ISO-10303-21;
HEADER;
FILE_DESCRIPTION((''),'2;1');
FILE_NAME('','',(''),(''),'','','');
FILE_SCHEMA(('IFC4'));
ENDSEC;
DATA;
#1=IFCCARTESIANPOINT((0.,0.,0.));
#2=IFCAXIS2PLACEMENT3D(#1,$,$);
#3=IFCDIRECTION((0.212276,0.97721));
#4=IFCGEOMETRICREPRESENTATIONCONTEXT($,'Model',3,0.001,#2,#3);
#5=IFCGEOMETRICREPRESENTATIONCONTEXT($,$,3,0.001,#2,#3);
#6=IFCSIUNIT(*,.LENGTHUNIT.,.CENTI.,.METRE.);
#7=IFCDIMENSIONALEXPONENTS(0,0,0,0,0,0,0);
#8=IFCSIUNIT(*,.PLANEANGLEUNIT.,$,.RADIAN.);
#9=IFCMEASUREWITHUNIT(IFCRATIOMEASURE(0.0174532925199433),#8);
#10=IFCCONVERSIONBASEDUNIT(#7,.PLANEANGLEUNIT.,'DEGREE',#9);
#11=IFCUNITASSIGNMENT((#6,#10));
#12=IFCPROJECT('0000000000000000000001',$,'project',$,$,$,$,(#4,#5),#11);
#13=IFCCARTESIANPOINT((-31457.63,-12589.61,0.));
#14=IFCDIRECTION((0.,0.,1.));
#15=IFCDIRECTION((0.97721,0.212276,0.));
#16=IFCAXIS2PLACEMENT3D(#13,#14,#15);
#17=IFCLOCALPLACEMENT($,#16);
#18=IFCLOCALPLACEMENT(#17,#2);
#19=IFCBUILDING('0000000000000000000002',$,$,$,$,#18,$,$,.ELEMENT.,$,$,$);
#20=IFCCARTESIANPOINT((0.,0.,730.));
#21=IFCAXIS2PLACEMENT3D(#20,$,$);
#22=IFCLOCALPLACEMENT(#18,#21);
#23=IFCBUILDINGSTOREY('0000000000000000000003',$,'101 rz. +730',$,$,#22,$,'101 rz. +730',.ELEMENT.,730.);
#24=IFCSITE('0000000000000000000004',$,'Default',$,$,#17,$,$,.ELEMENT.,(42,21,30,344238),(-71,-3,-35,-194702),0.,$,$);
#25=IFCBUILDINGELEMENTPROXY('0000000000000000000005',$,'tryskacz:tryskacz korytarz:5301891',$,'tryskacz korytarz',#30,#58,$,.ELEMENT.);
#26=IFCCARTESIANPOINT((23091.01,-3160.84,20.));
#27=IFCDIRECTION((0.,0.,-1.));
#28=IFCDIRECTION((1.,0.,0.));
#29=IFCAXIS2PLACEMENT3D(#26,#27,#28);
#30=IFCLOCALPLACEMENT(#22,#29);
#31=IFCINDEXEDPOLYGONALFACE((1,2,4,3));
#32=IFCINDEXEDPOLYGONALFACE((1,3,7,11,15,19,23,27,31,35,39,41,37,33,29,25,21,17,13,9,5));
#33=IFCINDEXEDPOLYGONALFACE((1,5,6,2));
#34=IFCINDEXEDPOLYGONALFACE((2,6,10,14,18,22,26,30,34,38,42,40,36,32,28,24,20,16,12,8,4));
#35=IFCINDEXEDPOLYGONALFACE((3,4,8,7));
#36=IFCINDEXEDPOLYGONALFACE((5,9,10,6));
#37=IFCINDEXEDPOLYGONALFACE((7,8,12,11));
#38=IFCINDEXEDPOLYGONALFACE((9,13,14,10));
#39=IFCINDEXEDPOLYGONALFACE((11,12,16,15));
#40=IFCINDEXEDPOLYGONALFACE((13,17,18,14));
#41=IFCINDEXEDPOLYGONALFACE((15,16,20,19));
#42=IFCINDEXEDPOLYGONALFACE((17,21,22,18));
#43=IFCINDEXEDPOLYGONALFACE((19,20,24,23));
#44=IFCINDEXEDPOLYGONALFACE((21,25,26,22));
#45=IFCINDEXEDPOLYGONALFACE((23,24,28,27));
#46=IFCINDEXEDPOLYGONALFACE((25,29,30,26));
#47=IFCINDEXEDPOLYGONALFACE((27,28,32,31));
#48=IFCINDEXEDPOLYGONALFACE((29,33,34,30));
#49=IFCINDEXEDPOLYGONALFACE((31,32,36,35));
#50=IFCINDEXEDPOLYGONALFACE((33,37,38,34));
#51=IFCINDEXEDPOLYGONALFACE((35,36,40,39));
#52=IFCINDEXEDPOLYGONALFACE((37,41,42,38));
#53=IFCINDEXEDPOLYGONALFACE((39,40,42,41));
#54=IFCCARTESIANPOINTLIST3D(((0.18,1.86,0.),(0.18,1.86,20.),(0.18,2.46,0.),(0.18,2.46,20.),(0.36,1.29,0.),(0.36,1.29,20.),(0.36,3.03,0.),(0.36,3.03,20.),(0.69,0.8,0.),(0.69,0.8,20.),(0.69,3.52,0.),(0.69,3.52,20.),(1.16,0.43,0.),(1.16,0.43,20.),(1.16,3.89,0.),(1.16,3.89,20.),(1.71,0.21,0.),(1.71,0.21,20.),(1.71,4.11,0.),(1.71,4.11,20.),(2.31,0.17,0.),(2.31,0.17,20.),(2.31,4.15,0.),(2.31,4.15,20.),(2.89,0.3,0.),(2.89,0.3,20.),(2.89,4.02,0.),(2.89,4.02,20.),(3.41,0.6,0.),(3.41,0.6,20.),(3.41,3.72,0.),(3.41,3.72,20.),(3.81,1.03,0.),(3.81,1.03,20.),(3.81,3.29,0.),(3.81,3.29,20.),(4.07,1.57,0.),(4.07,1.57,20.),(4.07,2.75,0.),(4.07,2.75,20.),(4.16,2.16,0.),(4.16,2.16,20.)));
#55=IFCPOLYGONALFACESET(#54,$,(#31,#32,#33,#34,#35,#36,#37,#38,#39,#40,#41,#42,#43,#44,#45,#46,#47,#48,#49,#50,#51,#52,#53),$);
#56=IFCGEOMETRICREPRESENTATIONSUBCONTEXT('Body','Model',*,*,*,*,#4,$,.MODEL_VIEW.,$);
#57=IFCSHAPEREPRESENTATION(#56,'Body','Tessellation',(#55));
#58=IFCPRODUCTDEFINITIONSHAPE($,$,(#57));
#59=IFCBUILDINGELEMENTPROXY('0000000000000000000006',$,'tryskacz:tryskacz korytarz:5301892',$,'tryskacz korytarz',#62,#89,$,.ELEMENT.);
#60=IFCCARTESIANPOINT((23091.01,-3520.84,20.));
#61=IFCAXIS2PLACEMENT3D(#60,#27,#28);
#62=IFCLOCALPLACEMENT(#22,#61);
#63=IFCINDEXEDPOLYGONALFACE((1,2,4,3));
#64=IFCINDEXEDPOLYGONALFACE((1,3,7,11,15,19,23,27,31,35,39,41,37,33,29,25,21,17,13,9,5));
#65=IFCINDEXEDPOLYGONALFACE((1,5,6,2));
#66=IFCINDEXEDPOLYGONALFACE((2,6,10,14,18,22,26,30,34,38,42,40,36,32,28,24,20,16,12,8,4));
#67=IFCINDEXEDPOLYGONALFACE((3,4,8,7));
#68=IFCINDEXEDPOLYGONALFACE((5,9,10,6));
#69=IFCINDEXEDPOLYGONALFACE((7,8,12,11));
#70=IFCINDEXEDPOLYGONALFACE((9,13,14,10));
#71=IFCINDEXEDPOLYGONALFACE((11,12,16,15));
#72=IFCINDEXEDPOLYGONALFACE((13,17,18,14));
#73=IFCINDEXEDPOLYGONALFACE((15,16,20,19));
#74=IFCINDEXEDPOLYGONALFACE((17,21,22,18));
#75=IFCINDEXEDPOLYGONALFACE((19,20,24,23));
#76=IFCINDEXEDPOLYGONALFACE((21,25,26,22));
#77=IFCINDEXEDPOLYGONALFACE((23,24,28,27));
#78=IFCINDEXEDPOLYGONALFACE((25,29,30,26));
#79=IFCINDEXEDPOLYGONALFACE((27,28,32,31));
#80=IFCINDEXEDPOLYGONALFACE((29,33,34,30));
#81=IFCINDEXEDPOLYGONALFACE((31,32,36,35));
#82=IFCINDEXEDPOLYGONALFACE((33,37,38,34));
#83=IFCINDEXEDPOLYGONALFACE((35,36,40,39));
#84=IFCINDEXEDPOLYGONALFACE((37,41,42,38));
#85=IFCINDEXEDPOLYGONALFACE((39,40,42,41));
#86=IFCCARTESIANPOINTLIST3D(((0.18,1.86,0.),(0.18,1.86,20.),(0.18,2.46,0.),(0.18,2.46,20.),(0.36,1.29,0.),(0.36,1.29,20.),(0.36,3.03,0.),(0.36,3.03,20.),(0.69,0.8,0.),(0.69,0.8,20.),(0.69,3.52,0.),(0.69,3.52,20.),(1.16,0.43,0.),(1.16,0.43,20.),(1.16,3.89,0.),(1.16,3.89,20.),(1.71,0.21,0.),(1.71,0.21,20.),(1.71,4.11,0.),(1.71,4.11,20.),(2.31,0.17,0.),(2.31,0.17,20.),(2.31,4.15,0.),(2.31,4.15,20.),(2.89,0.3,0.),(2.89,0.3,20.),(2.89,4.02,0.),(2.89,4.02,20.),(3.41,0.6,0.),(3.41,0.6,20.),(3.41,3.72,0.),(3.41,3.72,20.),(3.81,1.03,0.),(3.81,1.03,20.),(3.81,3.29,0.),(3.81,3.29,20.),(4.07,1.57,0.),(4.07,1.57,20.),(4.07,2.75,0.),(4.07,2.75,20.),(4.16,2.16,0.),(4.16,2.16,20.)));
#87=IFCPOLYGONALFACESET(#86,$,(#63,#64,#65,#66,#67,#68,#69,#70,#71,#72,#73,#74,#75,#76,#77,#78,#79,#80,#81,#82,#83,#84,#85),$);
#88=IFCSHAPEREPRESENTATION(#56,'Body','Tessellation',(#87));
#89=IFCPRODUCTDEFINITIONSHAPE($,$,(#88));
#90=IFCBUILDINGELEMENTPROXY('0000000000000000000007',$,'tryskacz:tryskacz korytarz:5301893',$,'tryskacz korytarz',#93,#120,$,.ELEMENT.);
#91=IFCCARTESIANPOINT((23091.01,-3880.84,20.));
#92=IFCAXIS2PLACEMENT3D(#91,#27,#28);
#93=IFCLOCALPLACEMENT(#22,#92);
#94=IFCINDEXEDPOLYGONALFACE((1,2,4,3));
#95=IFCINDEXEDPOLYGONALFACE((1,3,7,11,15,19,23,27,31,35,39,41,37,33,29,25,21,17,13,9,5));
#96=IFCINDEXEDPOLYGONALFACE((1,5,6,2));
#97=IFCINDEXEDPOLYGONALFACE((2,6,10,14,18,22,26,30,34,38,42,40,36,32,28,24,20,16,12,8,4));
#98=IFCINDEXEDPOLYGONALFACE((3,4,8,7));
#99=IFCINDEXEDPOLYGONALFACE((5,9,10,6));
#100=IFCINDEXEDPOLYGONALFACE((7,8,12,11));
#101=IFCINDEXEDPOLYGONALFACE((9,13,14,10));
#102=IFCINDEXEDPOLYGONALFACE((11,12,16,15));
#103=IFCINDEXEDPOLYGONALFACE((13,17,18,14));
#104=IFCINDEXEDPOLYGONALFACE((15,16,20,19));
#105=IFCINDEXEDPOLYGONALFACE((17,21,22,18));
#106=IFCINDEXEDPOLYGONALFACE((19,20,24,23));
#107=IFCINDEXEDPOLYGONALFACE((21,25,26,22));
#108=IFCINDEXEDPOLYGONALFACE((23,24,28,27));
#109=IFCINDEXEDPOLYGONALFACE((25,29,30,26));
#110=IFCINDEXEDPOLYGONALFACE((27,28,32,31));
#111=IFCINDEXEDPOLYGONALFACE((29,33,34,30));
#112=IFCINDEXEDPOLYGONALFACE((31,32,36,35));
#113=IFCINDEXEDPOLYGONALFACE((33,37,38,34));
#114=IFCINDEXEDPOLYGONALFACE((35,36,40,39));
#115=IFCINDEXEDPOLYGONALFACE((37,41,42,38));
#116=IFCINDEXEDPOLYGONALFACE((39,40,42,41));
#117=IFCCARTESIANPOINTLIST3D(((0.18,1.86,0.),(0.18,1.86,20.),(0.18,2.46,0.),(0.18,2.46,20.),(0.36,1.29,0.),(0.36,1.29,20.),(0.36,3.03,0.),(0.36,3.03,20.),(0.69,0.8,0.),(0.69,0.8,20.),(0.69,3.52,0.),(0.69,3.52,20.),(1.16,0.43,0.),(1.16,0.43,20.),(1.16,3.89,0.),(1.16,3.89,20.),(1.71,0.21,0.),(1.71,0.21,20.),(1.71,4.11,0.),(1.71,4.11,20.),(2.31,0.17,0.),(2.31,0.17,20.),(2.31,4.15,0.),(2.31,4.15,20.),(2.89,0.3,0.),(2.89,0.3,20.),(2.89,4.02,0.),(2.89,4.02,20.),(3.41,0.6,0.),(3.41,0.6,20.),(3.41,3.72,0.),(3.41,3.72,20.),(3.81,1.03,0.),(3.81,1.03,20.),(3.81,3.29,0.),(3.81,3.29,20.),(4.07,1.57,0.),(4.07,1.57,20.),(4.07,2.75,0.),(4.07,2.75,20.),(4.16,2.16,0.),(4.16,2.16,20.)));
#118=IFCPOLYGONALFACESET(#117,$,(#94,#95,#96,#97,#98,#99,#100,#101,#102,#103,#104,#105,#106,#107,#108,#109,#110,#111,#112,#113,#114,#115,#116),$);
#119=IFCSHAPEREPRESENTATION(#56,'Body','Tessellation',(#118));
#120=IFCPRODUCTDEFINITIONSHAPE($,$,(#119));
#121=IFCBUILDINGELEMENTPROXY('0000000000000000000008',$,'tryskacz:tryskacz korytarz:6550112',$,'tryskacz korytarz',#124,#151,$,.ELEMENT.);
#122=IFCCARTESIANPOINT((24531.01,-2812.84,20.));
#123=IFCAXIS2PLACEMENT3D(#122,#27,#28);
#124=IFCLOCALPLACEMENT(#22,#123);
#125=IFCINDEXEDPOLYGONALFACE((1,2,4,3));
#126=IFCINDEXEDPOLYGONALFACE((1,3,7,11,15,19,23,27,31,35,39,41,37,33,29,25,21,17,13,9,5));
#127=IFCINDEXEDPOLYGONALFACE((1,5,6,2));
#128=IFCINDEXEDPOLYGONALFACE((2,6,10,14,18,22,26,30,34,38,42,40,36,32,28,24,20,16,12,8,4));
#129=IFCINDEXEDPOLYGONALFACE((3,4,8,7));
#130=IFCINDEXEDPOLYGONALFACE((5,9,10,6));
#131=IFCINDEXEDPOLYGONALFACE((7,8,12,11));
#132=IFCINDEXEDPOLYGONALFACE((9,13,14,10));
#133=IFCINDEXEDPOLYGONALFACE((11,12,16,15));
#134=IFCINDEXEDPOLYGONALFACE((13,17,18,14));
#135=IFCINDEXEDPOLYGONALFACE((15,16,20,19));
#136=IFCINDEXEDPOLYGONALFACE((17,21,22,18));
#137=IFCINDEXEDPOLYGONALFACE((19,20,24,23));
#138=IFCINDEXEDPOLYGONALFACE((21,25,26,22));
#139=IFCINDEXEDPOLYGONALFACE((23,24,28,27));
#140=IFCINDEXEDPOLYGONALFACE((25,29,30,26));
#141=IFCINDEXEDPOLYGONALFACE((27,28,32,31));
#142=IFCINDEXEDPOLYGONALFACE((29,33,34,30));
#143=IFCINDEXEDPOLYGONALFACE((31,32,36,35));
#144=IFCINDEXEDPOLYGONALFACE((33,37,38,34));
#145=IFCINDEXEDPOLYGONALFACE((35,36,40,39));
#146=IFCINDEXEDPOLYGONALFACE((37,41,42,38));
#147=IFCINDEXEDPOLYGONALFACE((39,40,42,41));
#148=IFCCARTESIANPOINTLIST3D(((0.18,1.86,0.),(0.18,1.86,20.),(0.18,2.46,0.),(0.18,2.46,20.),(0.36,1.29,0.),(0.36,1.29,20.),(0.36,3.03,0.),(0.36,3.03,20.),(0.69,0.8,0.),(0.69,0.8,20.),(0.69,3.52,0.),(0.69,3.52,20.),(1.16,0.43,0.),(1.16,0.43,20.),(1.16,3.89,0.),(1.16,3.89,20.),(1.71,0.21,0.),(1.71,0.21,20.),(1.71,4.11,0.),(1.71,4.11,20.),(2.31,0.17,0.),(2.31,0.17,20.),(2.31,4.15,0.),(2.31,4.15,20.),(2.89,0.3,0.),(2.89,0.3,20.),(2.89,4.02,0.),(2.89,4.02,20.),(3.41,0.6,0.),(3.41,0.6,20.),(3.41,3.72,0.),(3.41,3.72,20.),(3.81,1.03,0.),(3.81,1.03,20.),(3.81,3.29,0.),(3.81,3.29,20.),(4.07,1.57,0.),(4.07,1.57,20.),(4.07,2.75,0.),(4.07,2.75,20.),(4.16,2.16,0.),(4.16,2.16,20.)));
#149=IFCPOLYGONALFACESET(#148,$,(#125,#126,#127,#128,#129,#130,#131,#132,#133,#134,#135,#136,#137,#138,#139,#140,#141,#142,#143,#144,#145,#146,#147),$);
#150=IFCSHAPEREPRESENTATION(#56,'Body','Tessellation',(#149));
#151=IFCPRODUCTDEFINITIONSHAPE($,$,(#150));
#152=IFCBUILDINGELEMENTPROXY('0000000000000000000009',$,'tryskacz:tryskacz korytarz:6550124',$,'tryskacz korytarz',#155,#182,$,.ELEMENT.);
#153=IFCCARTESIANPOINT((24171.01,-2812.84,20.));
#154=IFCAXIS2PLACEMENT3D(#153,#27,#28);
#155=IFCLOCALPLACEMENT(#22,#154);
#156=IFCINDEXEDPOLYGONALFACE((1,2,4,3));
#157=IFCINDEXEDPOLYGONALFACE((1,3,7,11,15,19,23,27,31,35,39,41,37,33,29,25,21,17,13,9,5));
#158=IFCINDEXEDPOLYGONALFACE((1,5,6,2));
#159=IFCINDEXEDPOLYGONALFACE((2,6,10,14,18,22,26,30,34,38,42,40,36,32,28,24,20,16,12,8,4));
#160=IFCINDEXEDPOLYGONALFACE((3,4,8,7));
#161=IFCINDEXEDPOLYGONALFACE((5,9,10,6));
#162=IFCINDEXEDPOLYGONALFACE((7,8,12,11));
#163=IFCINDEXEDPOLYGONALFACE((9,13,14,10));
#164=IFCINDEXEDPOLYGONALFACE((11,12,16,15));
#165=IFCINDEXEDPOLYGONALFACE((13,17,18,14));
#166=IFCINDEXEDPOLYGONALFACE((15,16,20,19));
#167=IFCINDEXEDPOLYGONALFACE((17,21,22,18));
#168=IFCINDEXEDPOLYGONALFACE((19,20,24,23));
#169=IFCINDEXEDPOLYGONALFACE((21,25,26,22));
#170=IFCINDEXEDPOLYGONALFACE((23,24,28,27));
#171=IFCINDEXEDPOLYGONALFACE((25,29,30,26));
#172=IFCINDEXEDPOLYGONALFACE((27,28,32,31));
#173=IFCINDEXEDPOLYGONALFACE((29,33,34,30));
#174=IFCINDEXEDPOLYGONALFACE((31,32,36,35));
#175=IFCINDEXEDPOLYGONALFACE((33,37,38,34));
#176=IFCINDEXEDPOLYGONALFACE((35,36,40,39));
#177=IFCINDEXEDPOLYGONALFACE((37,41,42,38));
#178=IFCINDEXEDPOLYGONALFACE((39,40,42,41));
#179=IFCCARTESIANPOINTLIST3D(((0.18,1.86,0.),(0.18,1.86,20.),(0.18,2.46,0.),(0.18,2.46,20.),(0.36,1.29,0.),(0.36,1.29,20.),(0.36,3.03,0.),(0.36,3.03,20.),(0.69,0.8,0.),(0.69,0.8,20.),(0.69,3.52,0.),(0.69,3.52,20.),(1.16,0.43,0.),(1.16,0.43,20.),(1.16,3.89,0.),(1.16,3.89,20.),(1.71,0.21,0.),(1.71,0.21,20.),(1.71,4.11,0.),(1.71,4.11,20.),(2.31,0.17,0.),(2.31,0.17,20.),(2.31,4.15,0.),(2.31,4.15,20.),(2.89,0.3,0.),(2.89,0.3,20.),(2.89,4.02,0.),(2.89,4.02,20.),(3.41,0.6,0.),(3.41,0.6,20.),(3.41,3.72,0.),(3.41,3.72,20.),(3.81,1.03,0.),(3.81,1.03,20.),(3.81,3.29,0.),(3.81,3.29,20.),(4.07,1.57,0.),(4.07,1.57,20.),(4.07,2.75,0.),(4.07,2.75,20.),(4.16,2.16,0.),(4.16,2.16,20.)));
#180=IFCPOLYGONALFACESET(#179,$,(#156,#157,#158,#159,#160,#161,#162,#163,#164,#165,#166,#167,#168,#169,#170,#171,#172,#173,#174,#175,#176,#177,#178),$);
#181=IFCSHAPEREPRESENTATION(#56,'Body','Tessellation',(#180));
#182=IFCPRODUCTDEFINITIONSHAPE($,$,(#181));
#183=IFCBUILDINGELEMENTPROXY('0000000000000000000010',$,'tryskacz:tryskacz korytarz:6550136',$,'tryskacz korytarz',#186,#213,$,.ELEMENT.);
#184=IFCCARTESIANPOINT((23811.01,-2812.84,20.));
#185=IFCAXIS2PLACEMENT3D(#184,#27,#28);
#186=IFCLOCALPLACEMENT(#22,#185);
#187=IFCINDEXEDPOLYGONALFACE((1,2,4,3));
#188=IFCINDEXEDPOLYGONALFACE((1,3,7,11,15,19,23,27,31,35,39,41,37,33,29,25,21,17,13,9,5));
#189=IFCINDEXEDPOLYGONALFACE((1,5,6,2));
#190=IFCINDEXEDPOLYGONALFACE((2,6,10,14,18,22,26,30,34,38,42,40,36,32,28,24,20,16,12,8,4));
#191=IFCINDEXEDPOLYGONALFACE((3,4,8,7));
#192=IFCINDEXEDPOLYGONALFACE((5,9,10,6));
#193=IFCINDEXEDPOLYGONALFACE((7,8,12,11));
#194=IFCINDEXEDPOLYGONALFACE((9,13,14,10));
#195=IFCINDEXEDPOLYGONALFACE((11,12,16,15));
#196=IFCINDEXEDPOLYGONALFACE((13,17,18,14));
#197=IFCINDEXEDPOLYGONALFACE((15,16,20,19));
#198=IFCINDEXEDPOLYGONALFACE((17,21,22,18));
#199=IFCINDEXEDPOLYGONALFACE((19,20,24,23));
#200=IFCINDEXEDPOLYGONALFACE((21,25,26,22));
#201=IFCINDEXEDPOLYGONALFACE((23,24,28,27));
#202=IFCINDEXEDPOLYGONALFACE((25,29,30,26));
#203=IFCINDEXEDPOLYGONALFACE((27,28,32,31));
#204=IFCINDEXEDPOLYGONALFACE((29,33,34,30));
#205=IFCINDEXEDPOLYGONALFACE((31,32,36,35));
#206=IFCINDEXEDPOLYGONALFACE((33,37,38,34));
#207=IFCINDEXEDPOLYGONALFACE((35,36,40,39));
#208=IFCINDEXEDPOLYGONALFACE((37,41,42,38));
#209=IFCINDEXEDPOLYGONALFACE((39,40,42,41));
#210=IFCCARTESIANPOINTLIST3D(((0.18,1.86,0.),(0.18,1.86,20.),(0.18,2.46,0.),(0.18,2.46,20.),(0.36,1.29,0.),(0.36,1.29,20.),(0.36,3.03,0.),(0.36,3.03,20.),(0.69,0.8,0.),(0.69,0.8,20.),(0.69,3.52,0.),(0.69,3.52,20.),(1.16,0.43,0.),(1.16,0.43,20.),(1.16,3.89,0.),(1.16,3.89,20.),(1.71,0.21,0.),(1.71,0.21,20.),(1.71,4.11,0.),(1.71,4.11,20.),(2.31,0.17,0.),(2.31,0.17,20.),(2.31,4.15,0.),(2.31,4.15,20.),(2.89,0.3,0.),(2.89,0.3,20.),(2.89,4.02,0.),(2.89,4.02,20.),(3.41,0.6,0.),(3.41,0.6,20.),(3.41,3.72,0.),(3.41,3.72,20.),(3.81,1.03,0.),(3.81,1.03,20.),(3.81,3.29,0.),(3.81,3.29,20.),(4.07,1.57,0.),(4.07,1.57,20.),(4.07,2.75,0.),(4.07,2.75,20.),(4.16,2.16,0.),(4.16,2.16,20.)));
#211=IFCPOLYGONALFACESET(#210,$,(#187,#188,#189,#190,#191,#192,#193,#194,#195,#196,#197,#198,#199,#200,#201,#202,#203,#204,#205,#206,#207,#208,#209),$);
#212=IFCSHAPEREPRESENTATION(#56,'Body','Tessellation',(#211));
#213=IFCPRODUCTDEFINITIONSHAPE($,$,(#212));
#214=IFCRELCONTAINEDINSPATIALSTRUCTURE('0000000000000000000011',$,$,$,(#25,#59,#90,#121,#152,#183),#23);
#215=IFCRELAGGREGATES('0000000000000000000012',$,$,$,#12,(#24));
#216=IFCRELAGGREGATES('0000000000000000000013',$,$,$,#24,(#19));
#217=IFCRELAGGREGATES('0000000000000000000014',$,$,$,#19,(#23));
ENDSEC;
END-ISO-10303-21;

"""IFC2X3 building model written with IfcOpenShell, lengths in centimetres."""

from ifc_helpers import new_model, entity, si_unit, converted_unit, direction, frame, frame_2d, origin, place, context, subcontext, project, spatial, circle, extrude, source, transform, mapped, element, save


model = new_model("IFC2X3")

# Units and contexts
model_context = context("Model", 3, precision=0.001, world=origin(), true_north=direction((0.212276, 0.97721)))
context_of_model = context(None, 3, precision=0.001, world=origin(), true_north=direction((0.212276, 0.97721)))
body_context = subcontext(model_context, "Body", "Model", "MODEL_VIEW")
ifc_project = project(units=[si_unit("LENGTHUNIT", "METRE", prefix="CENTI"), converted_unit("PLANEANGLEUNIT", "DEGREE", entity("IfcRatioMeasure", 0.0174532925199433), si_unit("PLANEANGLEUNIT", "RADIAN"), dimensions=[0, 0, 0, 0, 0, 0, 0])], contexts=[model_context, context_of_model])

# Site, building, storey
site_placement = place(None, frame((-31457.63, -12589.61, 0.0), z_axis=(0.0, 0.0, 1.0), x_axis=(0.97721, 0.212276, 0.0)))
site = spatial("IfcSite", under=ifc_project, at=site_placement, Name="Default", CompositionType="ELEMENT", RefLatitude=(42, 21, 30, 344238), RefLongitude=(-71, -3, -35, -194702), RefElevation=0.0)
building_placement = place(site_placement, origin())
building = spatial("IfcBuilding", under=site, at=building_placement, CompositionType="ELEMENT")
storey_placement = place(building_placement, frame((0.0, 0.0, 730.0)))
storey = spatial("IfcBuildingStorey", under=building, at=storey_placement, Name="101 rz. +730", LongName="101 rz. +730", CompositionType="ELEMENT", Elevation=730.0)

# Building element proxies
shared_shape_1 = source(origin(), body_context, "Body", "SweptSolid", [
    extrude(circle(Radius=2.0, at=frame_2d((0.0, 0.0), x_axis=(1.0, 0.0))), frame((2.16, 2.16, 0.0)), (0.0, 0.0, 1.0), 20.0),
])
for number, where, z_axis, x_axis, name in (
    (1, (23091.01, -3160.84, 20.0), (0.0, 0.0, -1.0), (1.0, 0.0, 0.0), "tryskacz:tryskacz korytarz:5301891"),
    (2, (23091.01, -3520.84, 20.0), (0.0, 0.0, -1.0), (1.0, 0.0, 0.0), "tryskacz:tryskacz korytarz:5301892"),
    (3, (23091.01, -3880.84, 20.0), (0.0, 0.0, -1.0), (1.0, 0.0, 0.0), "tryskacz:tryskacz korytarz:5301893"),
    (4, (24531.01, -2812.84, 20.0), (0.0, 0.0, -1.0), (1.0, 0.0, 0.0), "tryskacz:tryskacz korytarz:6550112"),
    (5, (24171.01, -2812.84, 20.0), (0.0, 0.0, -1.0), (1.0, 0.0, 0.0), "tryskacz:tryskacz korytarz:6550124"),
    (6, (23811.01, -2812.84, 20.0), (0.0, 0.0, -1.0), (1.0, 0.0, 0.0), "tryskacz:tryskacz korytarz:6550136"),
):
    element("IfcBuildingElementProxy", number, at=place(storey_placement, frame(where, z_axis=z_axis, x_axis=x_axis)), inside=storey, Name=name, ObjectType="tryskacz korytarz", CompositionType="ELEMENT", context=body_context, shape_type="MappedRepresentation", body=[
        mapped(shared_shape_1, transform((0.0, 0.0, 0.0), scale=1.0)),
    ])

save(model, "model.ifc")
